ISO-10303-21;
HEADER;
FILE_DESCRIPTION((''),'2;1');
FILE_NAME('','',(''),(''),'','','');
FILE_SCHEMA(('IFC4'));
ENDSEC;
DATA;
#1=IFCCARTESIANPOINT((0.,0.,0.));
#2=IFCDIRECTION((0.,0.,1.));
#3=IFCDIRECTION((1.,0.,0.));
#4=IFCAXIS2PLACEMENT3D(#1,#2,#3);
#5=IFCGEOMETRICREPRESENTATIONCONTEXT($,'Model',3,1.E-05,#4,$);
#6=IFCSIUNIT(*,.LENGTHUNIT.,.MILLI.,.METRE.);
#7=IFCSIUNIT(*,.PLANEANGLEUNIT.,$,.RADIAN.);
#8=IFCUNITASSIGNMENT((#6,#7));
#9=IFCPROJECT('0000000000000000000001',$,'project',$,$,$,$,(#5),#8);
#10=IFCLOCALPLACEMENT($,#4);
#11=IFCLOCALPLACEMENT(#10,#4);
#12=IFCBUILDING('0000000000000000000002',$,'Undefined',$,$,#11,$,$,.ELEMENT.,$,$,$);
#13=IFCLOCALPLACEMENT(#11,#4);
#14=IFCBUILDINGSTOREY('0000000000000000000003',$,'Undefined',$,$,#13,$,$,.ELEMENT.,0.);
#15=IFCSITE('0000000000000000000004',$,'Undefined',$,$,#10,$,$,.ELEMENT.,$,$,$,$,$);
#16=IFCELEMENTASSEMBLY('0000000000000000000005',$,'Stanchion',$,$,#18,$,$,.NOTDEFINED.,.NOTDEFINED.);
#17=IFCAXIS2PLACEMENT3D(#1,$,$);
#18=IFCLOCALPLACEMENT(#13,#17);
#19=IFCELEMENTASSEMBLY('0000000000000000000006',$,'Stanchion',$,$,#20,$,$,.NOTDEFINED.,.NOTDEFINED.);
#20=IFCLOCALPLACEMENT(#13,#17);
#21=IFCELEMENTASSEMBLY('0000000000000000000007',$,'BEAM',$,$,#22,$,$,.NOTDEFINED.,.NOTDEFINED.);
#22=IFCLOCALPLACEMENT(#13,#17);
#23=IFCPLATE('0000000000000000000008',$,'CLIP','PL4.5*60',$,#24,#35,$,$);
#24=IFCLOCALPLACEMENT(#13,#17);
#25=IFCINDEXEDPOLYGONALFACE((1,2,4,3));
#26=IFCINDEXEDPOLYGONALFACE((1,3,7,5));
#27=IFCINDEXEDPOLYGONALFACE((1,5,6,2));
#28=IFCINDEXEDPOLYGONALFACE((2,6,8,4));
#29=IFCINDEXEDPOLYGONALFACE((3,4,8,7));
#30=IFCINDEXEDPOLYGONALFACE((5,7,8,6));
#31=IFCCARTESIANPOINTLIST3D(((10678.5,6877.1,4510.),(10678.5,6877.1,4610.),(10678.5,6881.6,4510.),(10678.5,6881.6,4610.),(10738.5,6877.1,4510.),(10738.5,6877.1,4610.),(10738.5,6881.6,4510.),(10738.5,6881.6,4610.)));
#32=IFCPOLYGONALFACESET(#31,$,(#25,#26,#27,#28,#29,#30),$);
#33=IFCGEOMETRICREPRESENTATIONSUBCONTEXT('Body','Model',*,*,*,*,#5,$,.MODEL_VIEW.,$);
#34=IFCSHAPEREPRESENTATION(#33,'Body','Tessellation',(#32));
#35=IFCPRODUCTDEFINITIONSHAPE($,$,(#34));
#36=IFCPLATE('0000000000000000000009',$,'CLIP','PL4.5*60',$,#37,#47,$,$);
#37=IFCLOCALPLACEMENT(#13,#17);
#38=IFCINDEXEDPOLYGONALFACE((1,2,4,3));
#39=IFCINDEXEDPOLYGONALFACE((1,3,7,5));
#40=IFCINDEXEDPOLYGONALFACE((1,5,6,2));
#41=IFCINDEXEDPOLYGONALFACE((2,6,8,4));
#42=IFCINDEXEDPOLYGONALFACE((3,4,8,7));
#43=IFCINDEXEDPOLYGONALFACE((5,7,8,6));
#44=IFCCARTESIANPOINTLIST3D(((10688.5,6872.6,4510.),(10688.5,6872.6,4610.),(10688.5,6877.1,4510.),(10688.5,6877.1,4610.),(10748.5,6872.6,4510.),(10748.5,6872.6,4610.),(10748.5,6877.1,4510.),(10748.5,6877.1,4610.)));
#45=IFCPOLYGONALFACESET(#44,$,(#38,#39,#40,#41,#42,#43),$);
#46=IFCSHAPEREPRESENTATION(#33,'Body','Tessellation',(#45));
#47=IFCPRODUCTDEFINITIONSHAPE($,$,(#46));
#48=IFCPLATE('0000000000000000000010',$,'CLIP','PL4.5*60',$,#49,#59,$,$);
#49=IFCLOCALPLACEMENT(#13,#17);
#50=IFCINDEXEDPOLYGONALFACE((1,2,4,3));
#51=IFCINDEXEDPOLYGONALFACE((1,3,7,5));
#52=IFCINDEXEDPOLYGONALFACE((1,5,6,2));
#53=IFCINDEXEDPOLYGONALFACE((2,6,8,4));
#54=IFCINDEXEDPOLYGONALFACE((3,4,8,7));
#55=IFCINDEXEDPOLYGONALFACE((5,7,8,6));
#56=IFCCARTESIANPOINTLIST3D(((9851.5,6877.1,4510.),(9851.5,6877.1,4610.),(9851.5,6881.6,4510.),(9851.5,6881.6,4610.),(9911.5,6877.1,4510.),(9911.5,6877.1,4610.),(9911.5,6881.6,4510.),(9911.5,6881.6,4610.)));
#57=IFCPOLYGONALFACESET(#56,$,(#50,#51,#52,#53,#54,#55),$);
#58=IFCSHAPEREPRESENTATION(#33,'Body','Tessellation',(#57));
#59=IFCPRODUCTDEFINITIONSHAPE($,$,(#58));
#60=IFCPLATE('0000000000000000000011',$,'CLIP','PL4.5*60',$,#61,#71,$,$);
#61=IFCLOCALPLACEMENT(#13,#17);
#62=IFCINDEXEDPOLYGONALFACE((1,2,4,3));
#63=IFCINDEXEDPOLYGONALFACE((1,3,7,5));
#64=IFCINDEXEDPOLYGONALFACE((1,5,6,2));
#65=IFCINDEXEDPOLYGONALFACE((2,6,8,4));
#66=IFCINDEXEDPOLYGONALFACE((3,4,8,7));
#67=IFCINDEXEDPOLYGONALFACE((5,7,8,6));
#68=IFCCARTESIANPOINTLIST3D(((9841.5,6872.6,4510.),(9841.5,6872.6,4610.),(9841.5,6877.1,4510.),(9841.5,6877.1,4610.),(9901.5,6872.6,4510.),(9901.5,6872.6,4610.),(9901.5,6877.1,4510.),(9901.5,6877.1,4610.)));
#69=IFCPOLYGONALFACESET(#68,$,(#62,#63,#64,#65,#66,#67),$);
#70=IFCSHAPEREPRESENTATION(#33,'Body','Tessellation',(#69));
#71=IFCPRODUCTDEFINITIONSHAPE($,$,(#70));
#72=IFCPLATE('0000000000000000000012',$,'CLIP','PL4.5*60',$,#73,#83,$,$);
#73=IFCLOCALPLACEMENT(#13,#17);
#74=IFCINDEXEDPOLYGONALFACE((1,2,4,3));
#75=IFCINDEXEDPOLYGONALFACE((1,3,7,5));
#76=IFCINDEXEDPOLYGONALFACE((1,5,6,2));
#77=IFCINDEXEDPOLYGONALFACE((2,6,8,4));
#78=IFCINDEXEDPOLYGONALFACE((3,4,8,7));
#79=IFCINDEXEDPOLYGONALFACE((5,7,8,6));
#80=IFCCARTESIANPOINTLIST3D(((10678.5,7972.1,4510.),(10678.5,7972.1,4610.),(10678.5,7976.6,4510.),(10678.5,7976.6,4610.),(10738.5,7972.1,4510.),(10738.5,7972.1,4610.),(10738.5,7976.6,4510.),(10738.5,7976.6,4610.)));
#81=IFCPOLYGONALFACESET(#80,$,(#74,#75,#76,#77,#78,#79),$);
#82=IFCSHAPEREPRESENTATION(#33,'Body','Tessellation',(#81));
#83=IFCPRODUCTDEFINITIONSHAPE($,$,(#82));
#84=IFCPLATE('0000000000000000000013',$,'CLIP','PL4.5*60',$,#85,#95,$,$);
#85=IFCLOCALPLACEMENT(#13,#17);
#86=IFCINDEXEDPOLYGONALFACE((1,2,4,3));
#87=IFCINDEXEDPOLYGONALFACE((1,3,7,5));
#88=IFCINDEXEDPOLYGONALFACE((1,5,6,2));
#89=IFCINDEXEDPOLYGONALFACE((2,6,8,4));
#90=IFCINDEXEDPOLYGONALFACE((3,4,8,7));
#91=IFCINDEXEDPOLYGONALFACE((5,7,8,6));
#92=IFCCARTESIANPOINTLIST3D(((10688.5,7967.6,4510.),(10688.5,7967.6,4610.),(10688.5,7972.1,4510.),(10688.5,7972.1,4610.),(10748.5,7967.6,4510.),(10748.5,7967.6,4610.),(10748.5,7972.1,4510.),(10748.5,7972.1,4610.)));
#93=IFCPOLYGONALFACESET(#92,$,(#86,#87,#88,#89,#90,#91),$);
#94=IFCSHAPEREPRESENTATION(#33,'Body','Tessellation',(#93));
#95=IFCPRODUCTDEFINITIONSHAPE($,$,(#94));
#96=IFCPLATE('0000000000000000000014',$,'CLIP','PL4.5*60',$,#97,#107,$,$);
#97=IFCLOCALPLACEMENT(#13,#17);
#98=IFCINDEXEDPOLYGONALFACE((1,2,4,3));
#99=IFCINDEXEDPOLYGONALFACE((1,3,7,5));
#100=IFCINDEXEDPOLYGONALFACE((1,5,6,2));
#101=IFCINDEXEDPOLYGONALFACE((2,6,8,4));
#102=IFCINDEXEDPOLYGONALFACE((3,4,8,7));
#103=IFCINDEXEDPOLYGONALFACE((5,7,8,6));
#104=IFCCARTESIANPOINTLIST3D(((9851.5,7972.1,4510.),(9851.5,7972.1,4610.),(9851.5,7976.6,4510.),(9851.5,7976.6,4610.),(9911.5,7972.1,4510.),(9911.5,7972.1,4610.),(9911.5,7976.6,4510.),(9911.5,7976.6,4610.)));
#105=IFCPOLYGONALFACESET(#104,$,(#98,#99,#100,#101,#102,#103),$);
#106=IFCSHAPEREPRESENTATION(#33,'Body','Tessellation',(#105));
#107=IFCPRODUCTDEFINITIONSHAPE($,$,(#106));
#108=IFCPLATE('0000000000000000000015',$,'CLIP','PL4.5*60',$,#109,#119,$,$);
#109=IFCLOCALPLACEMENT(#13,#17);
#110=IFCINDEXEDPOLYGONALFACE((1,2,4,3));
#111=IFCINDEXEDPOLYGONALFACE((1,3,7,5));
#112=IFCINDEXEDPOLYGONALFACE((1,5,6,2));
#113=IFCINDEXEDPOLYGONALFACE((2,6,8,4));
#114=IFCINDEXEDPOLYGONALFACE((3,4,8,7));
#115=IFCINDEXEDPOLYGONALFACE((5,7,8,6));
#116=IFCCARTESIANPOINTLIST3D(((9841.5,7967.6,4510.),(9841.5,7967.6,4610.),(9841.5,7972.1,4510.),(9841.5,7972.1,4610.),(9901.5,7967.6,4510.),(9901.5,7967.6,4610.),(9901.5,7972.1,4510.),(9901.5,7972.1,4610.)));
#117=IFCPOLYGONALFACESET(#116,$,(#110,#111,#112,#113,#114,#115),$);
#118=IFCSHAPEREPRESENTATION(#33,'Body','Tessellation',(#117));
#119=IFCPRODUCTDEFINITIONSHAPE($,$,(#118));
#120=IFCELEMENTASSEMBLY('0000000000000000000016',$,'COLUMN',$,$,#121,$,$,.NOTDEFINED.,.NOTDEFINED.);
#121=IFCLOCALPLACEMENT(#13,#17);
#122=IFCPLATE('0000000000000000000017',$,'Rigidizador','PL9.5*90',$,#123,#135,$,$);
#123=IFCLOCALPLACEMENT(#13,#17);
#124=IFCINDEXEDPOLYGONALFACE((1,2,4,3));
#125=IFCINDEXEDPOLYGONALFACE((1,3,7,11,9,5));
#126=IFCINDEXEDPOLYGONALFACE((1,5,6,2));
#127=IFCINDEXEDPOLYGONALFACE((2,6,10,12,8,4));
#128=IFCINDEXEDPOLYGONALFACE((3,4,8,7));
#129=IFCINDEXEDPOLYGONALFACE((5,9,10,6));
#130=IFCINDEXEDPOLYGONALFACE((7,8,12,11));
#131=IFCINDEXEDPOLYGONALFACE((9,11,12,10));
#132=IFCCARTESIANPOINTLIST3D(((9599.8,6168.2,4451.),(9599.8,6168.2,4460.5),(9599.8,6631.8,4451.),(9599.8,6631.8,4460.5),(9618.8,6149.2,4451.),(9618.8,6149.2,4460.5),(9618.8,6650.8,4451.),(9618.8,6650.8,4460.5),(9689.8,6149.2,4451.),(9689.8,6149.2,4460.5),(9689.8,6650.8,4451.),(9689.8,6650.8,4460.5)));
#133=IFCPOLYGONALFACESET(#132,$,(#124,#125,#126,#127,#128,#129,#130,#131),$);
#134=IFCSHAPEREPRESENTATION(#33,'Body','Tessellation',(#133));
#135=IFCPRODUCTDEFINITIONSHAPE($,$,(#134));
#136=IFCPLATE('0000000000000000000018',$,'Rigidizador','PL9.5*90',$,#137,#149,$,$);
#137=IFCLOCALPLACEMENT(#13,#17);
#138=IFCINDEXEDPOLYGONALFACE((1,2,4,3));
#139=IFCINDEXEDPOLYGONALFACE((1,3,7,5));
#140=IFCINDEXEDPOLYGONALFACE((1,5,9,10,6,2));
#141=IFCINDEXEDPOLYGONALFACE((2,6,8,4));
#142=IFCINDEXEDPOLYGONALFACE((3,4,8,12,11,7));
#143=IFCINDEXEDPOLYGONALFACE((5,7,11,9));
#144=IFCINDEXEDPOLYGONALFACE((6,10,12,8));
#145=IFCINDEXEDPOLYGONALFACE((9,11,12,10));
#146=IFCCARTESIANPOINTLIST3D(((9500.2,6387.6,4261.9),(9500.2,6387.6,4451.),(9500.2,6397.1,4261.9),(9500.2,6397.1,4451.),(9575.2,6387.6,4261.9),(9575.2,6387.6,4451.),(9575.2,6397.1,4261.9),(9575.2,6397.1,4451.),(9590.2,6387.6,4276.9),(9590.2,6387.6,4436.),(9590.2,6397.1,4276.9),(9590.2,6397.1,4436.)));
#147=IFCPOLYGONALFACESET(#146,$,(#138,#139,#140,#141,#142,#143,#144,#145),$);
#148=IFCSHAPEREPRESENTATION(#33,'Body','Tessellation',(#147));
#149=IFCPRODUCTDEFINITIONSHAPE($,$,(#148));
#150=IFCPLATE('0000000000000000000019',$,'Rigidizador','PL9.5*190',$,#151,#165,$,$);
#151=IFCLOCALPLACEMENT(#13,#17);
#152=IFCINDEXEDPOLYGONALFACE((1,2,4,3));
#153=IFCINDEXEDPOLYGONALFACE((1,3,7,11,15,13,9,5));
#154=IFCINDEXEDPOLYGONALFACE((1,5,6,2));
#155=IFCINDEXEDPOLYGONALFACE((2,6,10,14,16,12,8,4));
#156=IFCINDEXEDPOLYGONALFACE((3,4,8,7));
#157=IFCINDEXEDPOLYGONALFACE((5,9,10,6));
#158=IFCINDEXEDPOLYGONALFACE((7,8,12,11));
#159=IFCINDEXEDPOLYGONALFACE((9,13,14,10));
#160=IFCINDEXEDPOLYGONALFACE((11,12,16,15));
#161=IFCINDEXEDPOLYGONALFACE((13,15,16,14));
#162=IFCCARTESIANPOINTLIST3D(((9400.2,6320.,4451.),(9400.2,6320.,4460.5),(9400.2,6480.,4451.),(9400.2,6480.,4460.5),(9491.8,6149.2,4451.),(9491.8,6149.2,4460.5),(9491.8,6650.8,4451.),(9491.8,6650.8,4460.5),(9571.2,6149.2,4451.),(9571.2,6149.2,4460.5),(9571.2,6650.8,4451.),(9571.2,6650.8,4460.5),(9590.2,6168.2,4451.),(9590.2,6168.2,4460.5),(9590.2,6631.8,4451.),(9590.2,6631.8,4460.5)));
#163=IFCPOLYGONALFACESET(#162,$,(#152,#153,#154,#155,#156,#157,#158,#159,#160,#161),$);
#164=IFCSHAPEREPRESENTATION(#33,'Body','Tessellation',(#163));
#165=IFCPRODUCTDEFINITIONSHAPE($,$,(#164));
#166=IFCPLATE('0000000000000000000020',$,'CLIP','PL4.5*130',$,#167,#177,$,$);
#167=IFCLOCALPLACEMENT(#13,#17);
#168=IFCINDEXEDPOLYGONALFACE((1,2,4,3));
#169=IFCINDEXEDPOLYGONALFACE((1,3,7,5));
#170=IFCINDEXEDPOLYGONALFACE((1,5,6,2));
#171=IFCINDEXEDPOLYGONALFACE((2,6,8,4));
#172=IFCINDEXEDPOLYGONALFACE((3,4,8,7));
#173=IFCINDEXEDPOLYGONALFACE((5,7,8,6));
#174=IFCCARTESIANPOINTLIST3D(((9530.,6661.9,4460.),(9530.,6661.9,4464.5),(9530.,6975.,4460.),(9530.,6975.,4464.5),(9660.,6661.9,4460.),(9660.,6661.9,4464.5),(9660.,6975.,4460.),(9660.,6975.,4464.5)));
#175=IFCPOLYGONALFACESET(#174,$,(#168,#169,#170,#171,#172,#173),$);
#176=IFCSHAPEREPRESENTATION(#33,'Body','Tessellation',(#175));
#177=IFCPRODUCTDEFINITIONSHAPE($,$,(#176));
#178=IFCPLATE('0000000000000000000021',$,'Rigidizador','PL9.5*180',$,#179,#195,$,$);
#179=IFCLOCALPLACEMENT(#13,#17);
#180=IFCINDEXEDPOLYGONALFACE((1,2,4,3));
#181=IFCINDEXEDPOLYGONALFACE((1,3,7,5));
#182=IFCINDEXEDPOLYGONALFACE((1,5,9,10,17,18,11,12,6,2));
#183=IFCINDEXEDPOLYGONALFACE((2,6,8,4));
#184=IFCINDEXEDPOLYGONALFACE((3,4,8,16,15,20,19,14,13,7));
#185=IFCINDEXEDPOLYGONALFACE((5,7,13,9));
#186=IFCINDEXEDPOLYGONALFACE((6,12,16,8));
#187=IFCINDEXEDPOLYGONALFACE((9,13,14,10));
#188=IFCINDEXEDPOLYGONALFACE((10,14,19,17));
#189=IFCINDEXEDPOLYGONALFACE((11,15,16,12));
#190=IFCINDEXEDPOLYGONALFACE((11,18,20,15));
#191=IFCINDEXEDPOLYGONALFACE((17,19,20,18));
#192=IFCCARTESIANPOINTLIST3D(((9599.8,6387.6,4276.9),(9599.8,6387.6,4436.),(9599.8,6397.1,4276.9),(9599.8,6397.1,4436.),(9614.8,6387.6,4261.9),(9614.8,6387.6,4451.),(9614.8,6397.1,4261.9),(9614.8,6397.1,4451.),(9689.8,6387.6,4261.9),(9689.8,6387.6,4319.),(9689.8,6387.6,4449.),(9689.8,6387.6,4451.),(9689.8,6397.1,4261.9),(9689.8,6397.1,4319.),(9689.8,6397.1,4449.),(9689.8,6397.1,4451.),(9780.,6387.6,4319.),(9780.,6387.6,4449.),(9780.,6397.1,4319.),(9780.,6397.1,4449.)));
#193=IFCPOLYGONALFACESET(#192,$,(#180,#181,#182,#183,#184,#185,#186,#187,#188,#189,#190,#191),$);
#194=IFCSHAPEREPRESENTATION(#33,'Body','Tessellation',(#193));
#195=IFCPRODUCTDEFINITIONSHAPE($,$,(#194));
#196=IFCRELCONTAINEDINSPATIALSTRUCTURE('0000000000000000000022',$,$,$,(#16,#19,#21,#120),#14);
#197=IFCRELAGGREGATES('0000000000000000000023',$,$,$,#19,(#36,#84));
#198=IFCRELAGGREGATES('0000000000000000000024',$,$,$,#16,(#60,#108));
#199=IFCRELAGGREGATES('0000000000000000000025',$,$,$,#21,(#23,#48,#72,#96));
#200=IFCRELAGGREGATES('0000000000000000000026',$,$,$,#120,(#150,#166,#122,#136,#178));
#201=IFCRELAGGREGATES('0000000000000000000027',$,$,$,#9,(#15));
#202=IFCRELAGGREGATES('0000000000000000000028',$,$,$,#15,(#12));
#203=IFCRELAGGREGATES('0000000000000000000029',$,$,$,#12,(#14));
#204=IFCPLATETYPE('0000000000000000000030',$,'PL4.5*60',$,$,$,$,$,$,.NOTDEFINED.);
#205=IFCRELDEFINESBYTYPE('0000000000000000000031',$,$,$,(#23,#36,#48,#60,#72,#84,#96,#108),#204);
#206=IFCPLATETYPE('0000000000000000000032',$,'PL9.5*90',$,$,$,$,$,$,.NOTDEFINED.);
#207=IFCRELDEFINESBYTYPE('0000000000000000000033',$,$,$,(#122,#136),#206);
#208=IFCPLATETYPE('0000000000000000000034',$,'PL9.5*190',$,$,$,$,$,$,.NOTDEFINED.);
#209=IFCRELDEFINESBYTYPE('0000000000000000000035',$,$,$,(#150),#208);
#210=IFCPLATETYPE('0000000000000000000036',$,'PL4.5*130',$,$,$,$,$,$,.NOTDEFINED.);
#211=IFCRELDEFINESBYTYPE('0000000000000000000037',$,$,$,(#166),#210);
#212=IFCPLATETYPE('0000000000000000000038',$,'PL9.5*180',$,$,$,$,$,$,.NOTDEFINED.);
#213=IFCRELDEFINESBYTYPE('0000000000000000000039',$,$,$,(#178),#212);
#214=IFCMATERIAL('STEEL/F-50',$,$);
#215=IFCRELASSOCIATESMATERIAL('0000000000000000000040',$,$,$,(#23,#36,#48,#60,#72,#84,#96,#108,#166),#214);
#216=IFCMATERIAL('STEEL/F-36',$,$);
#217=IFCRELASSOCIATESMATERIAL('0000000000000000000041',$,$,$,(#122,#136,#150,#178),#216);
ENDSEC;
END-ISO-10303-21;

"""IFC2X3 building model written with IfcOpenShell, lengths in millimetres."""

from ifc_helpers import new_model, si_unit, frame, origin_with_axes, place, context, subcontext, project, spatial, polyline, outline, extrude, material, type_object, element, aggregate, save


model = new_model("IFC2X3")

# Units and contexts
model_context = context("Model", 3, precision=1e-05, world=origin_with_axes())
body_context = subcontext(model_context, "Body", "Model", "MODEL_VIEW")
ifc_project = project(units=[si_unit("LENGTHUNIT", "METRE", prefix="MILLI"), si_unit("PLANEANGLEUNIT", "RADIAN")], contexts=[model_context])

# Site, building, storey
site_placement = place(None, origin_with_axes())
site = spatial("IfcSite", under=ifc_project, at=site_placement, Name="Undefined", CompositionType="ELEMENT")
building_placement = place(site_placement, origin_with_axes())
building = spatial("IfcBuilding", under=site, at=building_placement, Name="Undefined", CompositionType="ELEMENT")
storey_placement = place(building_placement, origin_with_axes())
storey = spatial("IfcBuildingStorey", under=building, at=storey_placement, Name="Undefined", CompositionType="ELEMENT", Elevation=0.0)

# Element assemblies
assembly_1_placement = place(storey_placement, origin_with_axes())
assembly_1 = element("IfcElementAssembly", 1, at=assembly_1_placement, inside=storey, Name="Stanchion", AssemblyPlace="NOTDEFINED", PredefinedType="NOTDEFINED")
assembly_2_placement = place(storey_placement, origin_with_axes())
assembly_2 = element("IfcElementAssembly", 2, at=assembly_2_placement, inside=storey, Name="Stanchion", AssemblyPlace="NOTDEFINED", PredefinedType="NOTDEFINED")

# Shared definitions
ifc_material_1 = material(Name="STEEL/F-36")

# Element assembly
assembly_3_placement = place(storey_placement, origin_with_axes())
assembly_3 = element("IfcElementAssembly", 3, at=assembly_3_placement, inside=storey, Name="BEAM", AssemblyPlace="NOTDEFINED", PredefinedType="NOTDEFINED")
ifc_material_2 = material(Name="STEEL/F-50")
plate_type_1 = type_object("IfcPlateType", Name="PL4.5*60", PredefinedType="NOTDEFINED")

# Plates
plate_1_placement = place(assembly_3_placement, frame((10738.5, 6879.3, 4510.0), z_axis=(0.0, 1.0, 0.0), x_axis=(-1.0, 0.0, 0.0)))
plate_1 = element("IfcPlate", 4, at=plate_1_placement, type_object=plate_type_1, material=ifc_material_2, Name="CLIP", Description="PL4.5*60", context=body_context, shape_type="SweptSolid", body=[
    extrude(outline(polyline([(0.0, 0.0), (60.0, 0.0), (60.0, 100.0), (0.0, 100.0), (0.0, 0.0)])), frame((0.0, 0.0, -2.2), z_axis=(0.0, 0.0, 1.0), x_axis=(1.0, 0.0, 0.0)), (0.0, 0.0, 1.0), 4.5),
])
plate_2_placement = place(assembly_2_placement, frame((10748.5, 6874.8, 4510.0), z_axis=(0.0, 1.0, 0.0), x_axis=(-1.0, 0.0, 0.0)))
plate_2 = element("IfcPlate", 5, at=plate_2_placement, type_object=plate_type_1, material=ifc_material_2, Name="CLIP", Description="PL4.5*60", context=body_context, shape_type="SweptSolid", body=[
    extrude(outline(polyline([(0.0, 0.0), (60.0, 0.0), (60.0, 100.0), (0.0, 100.0), (0.0, 0.0)])), frame((0.0, 0.0, -2.2), z_axis=(0.0, 0.0, 1.0), x_axis=(1.0, 0.0, 0.0)), (0.0, 0.0, 1.0), 4.5),
])
plate_3_placement = place(assembly_3_placement, frame((9851.5, 6879.3, 4510.0), z_axis=(0.0, -1.0, 0.0), x_axis=(1.0, 0.0, 0.0)))
plate_3 = element("IfcPlate", 6, at=plate_3_placement, type_object=plate_type_1, material=ifc_material_2, Name="CLIP", Description="PL4.5*60", context=body_context, shape_type="SweptSolid", body=[
    extrude(outline(polyline([(0.0, 0.0), (60.0, 0.0), (60.0, 100.0), (0.0, 100.0), (0.0, 0.0)])), frame((0.0, 0.0, -2.2), z_axis=(0.0, 0.0, 1.0), x_axis=(1.0, 0.0, 0.0)), (0.0, 0.0, 1.0), 4.5),
])
plate_4_placement = place(assembly_1_placement, frame((9841.5, 6874.8, 4510.0), z_axis=(0.0, -1.0, 0.0), x_axis=(1.0, 0.0, 0.0)))
plate_4 = element("IfcPlate", 7, at=plate_4_placement, type_object=plate_type_1, material=ifc_material_2, Name="CLIP", Description="PL4.5*60", context=body_context, shape_type="SweptSolid", body=[
    extrude(outline(polyline([(0.0, 0.0), (60.0, 0.0), (60.0, 100.0), (0.0, 100.0), (0.0, 0.0)])), frame((0.0, 0.0, -2.2), z_axis=(0.0, 0.0, 1.0), x_axis=(1.0, 0.0, 0.0)), (0.0, 0.0, 1.0), 4.5),
])
plate_5_placement = place(assembly_3_placement, frame((10738.5, 7974.3, 4510.0), z_axis=(0.0, 1.0, 0.0), x_axis=(-1.0, 0.0, 0.0)))
plate_5 = element("IfcPlate", 8, at=plate_5_placement, type_object=plate_type_1, material=ifc_material_2, Name="CLIP", Description="PL4.5*60", context=body_context, shape_type="SweptSolid", body=[
    extrude(outline(polyline([(0.0, 0.0), (60.0, 0.0), (60.0, 100.0), (0.0, 100.0), (0.0, 0.0)])), frame((0.0, 0.0, -2.2), z_axis=(0.0, 0.0, 1.0), x_axis=(1.0, 0.0, 0.0)), (0.0, 0.0, 1.0), 4.5),
])
plate_6_placement = place(assembly_2_placement, frame((10748.5, 7969.8, 4510.0), z_axis=(0.0, 1.0, 0.0), x_axis=(-1.0, 0.0, 0.0)))
plate_6 = element("IfcPlate", 9, at=plate_6_placement, type_object=plate_type_1, material=ifc_material_2, Name="CLIP", Description="PL4.5*60", context=body_context, shape_type="SweptSolid", body=[
    extrude(outline(polyline([(0.0, 0.0), (60.0, 0.0), (60.0, 100.0), (0.0, 100.0), (0.0, 0.0)])), frame((0.0, 0.0, -2.2), z_axis=(0.0, 0.0, 1.0), x_axis=(1.0, 0.0, 0.0)), (0.0, 0.0, 1.0), 4.5),
])
aggregate(assembly_2, [plate_2, plate_6])
plate_7_placement = place(assembly_3_placement, frame((9851.5, 7974.3, 4510.0), z_axis=(0.0, -1.0, 0.0), x_axis=(1.0, 0.0, 0.0)))
plate_7 = element("IfcPlate", 10, at=plate_7_placement, type_object=plate_type_1, material=ifc_material_2, Name="CLIP", Description="PL4.5*60", context=body_context, shape_type="SweptSolid", body=[
    extrude(outline(polyline([(0.0, 0.0), (60.0, 0.0), (60.0, 100.0), (0.0, 100.0), (0.0, 0.0)])), frame((0.0, 0.0, -2.2), z_axis=(0.0, 0.0, 1.0), x_axis=(1.0, 0.0, 0.0)), (0.0, 0.0, 1.0), 4.5),
])
plate_8_placement = place(assembly_1_placement, frame((9841.5, 7969.8, 4510.0), z_axis=(0.0, -1.0, 0.0), x_axis=(1.0, 0.0, 0.0)))
plate_8 = element("IfcPlate", 11, at=plate_8_placement, type_object=plate_type_1, material=ifc_material_2, Name="CLIP", Description="PL4.5*60", context=body_context, shape_type="SweptSolid", body=[
    extrude(outline(polyline([(0.0, 0.0), (60.0, 0.0), (60.0, 100.0), (0.0, 100.0), (0.0, 0.0)])), frame((0.0, 0.0, -2.2), z_axis=(0.0, 0.0, 1.0), x_axis=(1.0, 0.0, 0.0)), (0.0, 0.0, 1.0), 4.5),
])
aggregate(assembly_1, [plate_4, plate_8])

# Element assembly, plates
assembly_4_placement = place(storey_placement, origin_with_axes())
assembly_4 = element("IfcElementAssembly", 12, at=assembly_4_placement, inside=storey, Name="COLUMN", AssemblyPlace="NOTDEFINED", PredefinedType="NOTDEFINED")
plate_type_2 = type_object("IfcPlateType", Name="PL9.5*90", PredefinedType="NOTDEFINED")
plate_9_placement = place(assembly_4_placement, frame((9689.8, 6650.8, 4455.8), z_axis=(0.0, 0.0, 1.0), x_axis=(-1.0, 0.0, 0.0)))
plate_9 = element("IfcPlate", 13, at=plate_9_placement, type_object=plate_type_2, material=ifc_material_1, Name="Rigidizador", Description="PL9.5*90", context=body_context, shape_type="SweptSolid", body=[
    extrude(outline(polyline([(0.0, 0.0), (71.0, 0.0), (90.0, 19.0), (90.0, 482.6), (71.0, 501.6), (0.0, 501.6), (0.0, 0.0)])), frame((0.0, 0.0, -4.8), z_axis=(0.0, 0.0, 1.0), x_axis=(1.0, 0.0, 0.0)), (0.0, 0.0, 1.0), 9.5),
])
plate_10_placement = place(assembly_4_placement, frame((9500.2, 6392.4, 4451.0), z_axis=(0.0, 1.0, 0.0), x_axis=(1.0, 0.0, -0.000004)))
plate_10 = element("IfcPlate", 14, at=plate_10_placement, type_object=plate_type_2, material=ifc_material_1, Name="Rigidizador", Description="PL9.5*90", context=body_context, shape_type="SweptSolid", body=[
    extrude(outline(polyline([(0.0, 0.0), (75.0, 0.0), (90.0, 15.0), (90.0, 174.1), (75.0, 189.1), (0.0, 189.1), (0.0, 0.0)])), frame((0.0, 0.0, -4.8), z_axis=(0.0, 0.0, 1.0), x_axis=(1.0, 0.0, 0.0)), (0.0, 0.0, 1.0), 9.5),
])
plate_type_3 = type_object("IfcPlateType", Name="PL9.5*190", PredefinedType="NOTDEFINED")
plate_11_placement = place(assembly_4_placement, frame((9491.8, 6650.8, 4455.8), z_axis=(0.0, 0.0, -1.0), x_axis=(1.0, 0.0, 0.0)))
plate_11 = element("IfcPlate", 15, at=plate_11_placement, type_object=plate_type_3, material=ifc_material_1, Name="Rigidizador", Description="PL9.5*190", context=body_context, shape_type="SweptSolid", body=[
    extrude(outline(polyline([(0.0, 0.0), (79.4, 0.0), (98.4, 19.0), (98.4, 482.6), (79.4, 501.6), (0.0, 501.6), (-91.6, 330.8), (-91.6, 170.8), (0.0, 0.0)])), frame((0.0, 0.0, -4.8), z_axis=(0.0, 0.0, 1.0), x_axis=(1.0, 0.0, 0.0)), (0.0, 0.0, 1.0), 9.5),
])
plate_type_4 = type_object("IfcPlateType", Name="PL4.5*130", PredefinedType="NOTDEFINED")
plate_12_placement = place(assembly_4_placement, frame((9530.0, 6975.0, 4462.2), z_axis=(0.0, 0.0, 1.0), x_axis=(0.0, -1.0, 0.0)))
plate_12 = element("IfcPlate", 16, at=plate_12_placement, type_object=plate_type_4, material=ifc_material_2, Name="CLIP", Description="PL4.5*130", context=body_context, shape_type="SweptSolid", body=[
    extrude(outline(polyline([(0.0, 0.0), (313.1, 0.0), (313.1, 130.0), (0.0, 130.0), (0.0, 0.0)])), frame((0.0, 0.0, -2.2), z_axis=(0.0, 0.0, 1.0), x_axis=(1.0, 0.0, 0.0)), (0.0, 0.0, 1.0), 4.5),
])
plate_type_5 = type_object("IfcPlateType", Name="PL9.5*180", PredefinedType="NOTDEFINED")
plate_13_placement = place(assembly_4_placement, frame((9689.8, 6392.4, 4451.0), z_axis=(0.0, -1.0, 0.0), x_axis=(-1.0, 0.0, -0.000004)))
plate_13 = element("IfcPlate", 17, at=plate_13_placement, type_object=plate_type_5, material=ifc_material_1, Name="Rigidizador", Description="PL9.5*180", context=body_context, shape_type="SweptSolid", body=[
    extrude(outline(polyline([(0.0, 0.0), (75.0, 0.0), (90.0, 15.0), (90.0, 174.1), (75.0, 189.1), (0.0, 189.1), (0.0, 132.0), (-90.2, 132.0), (-90.2, 2.0), (0.0, 2.0), (0.0, 0.0)])), frame((0.0, 0.0, -4.8), z_axis=(0.0, 0.0, 1.0), x_axis=(1.0, 0.0, 0.0)), (0.0, 0.0, 1.0), 9.5),
])

aggregate(assembly_3, [plate_1, plate_3, plate_5, plate_7])

aggregate(assembly_4, [plate_11, plate_12, plate_9, plate_10, plate_13])

save(model, "model.ifc")
